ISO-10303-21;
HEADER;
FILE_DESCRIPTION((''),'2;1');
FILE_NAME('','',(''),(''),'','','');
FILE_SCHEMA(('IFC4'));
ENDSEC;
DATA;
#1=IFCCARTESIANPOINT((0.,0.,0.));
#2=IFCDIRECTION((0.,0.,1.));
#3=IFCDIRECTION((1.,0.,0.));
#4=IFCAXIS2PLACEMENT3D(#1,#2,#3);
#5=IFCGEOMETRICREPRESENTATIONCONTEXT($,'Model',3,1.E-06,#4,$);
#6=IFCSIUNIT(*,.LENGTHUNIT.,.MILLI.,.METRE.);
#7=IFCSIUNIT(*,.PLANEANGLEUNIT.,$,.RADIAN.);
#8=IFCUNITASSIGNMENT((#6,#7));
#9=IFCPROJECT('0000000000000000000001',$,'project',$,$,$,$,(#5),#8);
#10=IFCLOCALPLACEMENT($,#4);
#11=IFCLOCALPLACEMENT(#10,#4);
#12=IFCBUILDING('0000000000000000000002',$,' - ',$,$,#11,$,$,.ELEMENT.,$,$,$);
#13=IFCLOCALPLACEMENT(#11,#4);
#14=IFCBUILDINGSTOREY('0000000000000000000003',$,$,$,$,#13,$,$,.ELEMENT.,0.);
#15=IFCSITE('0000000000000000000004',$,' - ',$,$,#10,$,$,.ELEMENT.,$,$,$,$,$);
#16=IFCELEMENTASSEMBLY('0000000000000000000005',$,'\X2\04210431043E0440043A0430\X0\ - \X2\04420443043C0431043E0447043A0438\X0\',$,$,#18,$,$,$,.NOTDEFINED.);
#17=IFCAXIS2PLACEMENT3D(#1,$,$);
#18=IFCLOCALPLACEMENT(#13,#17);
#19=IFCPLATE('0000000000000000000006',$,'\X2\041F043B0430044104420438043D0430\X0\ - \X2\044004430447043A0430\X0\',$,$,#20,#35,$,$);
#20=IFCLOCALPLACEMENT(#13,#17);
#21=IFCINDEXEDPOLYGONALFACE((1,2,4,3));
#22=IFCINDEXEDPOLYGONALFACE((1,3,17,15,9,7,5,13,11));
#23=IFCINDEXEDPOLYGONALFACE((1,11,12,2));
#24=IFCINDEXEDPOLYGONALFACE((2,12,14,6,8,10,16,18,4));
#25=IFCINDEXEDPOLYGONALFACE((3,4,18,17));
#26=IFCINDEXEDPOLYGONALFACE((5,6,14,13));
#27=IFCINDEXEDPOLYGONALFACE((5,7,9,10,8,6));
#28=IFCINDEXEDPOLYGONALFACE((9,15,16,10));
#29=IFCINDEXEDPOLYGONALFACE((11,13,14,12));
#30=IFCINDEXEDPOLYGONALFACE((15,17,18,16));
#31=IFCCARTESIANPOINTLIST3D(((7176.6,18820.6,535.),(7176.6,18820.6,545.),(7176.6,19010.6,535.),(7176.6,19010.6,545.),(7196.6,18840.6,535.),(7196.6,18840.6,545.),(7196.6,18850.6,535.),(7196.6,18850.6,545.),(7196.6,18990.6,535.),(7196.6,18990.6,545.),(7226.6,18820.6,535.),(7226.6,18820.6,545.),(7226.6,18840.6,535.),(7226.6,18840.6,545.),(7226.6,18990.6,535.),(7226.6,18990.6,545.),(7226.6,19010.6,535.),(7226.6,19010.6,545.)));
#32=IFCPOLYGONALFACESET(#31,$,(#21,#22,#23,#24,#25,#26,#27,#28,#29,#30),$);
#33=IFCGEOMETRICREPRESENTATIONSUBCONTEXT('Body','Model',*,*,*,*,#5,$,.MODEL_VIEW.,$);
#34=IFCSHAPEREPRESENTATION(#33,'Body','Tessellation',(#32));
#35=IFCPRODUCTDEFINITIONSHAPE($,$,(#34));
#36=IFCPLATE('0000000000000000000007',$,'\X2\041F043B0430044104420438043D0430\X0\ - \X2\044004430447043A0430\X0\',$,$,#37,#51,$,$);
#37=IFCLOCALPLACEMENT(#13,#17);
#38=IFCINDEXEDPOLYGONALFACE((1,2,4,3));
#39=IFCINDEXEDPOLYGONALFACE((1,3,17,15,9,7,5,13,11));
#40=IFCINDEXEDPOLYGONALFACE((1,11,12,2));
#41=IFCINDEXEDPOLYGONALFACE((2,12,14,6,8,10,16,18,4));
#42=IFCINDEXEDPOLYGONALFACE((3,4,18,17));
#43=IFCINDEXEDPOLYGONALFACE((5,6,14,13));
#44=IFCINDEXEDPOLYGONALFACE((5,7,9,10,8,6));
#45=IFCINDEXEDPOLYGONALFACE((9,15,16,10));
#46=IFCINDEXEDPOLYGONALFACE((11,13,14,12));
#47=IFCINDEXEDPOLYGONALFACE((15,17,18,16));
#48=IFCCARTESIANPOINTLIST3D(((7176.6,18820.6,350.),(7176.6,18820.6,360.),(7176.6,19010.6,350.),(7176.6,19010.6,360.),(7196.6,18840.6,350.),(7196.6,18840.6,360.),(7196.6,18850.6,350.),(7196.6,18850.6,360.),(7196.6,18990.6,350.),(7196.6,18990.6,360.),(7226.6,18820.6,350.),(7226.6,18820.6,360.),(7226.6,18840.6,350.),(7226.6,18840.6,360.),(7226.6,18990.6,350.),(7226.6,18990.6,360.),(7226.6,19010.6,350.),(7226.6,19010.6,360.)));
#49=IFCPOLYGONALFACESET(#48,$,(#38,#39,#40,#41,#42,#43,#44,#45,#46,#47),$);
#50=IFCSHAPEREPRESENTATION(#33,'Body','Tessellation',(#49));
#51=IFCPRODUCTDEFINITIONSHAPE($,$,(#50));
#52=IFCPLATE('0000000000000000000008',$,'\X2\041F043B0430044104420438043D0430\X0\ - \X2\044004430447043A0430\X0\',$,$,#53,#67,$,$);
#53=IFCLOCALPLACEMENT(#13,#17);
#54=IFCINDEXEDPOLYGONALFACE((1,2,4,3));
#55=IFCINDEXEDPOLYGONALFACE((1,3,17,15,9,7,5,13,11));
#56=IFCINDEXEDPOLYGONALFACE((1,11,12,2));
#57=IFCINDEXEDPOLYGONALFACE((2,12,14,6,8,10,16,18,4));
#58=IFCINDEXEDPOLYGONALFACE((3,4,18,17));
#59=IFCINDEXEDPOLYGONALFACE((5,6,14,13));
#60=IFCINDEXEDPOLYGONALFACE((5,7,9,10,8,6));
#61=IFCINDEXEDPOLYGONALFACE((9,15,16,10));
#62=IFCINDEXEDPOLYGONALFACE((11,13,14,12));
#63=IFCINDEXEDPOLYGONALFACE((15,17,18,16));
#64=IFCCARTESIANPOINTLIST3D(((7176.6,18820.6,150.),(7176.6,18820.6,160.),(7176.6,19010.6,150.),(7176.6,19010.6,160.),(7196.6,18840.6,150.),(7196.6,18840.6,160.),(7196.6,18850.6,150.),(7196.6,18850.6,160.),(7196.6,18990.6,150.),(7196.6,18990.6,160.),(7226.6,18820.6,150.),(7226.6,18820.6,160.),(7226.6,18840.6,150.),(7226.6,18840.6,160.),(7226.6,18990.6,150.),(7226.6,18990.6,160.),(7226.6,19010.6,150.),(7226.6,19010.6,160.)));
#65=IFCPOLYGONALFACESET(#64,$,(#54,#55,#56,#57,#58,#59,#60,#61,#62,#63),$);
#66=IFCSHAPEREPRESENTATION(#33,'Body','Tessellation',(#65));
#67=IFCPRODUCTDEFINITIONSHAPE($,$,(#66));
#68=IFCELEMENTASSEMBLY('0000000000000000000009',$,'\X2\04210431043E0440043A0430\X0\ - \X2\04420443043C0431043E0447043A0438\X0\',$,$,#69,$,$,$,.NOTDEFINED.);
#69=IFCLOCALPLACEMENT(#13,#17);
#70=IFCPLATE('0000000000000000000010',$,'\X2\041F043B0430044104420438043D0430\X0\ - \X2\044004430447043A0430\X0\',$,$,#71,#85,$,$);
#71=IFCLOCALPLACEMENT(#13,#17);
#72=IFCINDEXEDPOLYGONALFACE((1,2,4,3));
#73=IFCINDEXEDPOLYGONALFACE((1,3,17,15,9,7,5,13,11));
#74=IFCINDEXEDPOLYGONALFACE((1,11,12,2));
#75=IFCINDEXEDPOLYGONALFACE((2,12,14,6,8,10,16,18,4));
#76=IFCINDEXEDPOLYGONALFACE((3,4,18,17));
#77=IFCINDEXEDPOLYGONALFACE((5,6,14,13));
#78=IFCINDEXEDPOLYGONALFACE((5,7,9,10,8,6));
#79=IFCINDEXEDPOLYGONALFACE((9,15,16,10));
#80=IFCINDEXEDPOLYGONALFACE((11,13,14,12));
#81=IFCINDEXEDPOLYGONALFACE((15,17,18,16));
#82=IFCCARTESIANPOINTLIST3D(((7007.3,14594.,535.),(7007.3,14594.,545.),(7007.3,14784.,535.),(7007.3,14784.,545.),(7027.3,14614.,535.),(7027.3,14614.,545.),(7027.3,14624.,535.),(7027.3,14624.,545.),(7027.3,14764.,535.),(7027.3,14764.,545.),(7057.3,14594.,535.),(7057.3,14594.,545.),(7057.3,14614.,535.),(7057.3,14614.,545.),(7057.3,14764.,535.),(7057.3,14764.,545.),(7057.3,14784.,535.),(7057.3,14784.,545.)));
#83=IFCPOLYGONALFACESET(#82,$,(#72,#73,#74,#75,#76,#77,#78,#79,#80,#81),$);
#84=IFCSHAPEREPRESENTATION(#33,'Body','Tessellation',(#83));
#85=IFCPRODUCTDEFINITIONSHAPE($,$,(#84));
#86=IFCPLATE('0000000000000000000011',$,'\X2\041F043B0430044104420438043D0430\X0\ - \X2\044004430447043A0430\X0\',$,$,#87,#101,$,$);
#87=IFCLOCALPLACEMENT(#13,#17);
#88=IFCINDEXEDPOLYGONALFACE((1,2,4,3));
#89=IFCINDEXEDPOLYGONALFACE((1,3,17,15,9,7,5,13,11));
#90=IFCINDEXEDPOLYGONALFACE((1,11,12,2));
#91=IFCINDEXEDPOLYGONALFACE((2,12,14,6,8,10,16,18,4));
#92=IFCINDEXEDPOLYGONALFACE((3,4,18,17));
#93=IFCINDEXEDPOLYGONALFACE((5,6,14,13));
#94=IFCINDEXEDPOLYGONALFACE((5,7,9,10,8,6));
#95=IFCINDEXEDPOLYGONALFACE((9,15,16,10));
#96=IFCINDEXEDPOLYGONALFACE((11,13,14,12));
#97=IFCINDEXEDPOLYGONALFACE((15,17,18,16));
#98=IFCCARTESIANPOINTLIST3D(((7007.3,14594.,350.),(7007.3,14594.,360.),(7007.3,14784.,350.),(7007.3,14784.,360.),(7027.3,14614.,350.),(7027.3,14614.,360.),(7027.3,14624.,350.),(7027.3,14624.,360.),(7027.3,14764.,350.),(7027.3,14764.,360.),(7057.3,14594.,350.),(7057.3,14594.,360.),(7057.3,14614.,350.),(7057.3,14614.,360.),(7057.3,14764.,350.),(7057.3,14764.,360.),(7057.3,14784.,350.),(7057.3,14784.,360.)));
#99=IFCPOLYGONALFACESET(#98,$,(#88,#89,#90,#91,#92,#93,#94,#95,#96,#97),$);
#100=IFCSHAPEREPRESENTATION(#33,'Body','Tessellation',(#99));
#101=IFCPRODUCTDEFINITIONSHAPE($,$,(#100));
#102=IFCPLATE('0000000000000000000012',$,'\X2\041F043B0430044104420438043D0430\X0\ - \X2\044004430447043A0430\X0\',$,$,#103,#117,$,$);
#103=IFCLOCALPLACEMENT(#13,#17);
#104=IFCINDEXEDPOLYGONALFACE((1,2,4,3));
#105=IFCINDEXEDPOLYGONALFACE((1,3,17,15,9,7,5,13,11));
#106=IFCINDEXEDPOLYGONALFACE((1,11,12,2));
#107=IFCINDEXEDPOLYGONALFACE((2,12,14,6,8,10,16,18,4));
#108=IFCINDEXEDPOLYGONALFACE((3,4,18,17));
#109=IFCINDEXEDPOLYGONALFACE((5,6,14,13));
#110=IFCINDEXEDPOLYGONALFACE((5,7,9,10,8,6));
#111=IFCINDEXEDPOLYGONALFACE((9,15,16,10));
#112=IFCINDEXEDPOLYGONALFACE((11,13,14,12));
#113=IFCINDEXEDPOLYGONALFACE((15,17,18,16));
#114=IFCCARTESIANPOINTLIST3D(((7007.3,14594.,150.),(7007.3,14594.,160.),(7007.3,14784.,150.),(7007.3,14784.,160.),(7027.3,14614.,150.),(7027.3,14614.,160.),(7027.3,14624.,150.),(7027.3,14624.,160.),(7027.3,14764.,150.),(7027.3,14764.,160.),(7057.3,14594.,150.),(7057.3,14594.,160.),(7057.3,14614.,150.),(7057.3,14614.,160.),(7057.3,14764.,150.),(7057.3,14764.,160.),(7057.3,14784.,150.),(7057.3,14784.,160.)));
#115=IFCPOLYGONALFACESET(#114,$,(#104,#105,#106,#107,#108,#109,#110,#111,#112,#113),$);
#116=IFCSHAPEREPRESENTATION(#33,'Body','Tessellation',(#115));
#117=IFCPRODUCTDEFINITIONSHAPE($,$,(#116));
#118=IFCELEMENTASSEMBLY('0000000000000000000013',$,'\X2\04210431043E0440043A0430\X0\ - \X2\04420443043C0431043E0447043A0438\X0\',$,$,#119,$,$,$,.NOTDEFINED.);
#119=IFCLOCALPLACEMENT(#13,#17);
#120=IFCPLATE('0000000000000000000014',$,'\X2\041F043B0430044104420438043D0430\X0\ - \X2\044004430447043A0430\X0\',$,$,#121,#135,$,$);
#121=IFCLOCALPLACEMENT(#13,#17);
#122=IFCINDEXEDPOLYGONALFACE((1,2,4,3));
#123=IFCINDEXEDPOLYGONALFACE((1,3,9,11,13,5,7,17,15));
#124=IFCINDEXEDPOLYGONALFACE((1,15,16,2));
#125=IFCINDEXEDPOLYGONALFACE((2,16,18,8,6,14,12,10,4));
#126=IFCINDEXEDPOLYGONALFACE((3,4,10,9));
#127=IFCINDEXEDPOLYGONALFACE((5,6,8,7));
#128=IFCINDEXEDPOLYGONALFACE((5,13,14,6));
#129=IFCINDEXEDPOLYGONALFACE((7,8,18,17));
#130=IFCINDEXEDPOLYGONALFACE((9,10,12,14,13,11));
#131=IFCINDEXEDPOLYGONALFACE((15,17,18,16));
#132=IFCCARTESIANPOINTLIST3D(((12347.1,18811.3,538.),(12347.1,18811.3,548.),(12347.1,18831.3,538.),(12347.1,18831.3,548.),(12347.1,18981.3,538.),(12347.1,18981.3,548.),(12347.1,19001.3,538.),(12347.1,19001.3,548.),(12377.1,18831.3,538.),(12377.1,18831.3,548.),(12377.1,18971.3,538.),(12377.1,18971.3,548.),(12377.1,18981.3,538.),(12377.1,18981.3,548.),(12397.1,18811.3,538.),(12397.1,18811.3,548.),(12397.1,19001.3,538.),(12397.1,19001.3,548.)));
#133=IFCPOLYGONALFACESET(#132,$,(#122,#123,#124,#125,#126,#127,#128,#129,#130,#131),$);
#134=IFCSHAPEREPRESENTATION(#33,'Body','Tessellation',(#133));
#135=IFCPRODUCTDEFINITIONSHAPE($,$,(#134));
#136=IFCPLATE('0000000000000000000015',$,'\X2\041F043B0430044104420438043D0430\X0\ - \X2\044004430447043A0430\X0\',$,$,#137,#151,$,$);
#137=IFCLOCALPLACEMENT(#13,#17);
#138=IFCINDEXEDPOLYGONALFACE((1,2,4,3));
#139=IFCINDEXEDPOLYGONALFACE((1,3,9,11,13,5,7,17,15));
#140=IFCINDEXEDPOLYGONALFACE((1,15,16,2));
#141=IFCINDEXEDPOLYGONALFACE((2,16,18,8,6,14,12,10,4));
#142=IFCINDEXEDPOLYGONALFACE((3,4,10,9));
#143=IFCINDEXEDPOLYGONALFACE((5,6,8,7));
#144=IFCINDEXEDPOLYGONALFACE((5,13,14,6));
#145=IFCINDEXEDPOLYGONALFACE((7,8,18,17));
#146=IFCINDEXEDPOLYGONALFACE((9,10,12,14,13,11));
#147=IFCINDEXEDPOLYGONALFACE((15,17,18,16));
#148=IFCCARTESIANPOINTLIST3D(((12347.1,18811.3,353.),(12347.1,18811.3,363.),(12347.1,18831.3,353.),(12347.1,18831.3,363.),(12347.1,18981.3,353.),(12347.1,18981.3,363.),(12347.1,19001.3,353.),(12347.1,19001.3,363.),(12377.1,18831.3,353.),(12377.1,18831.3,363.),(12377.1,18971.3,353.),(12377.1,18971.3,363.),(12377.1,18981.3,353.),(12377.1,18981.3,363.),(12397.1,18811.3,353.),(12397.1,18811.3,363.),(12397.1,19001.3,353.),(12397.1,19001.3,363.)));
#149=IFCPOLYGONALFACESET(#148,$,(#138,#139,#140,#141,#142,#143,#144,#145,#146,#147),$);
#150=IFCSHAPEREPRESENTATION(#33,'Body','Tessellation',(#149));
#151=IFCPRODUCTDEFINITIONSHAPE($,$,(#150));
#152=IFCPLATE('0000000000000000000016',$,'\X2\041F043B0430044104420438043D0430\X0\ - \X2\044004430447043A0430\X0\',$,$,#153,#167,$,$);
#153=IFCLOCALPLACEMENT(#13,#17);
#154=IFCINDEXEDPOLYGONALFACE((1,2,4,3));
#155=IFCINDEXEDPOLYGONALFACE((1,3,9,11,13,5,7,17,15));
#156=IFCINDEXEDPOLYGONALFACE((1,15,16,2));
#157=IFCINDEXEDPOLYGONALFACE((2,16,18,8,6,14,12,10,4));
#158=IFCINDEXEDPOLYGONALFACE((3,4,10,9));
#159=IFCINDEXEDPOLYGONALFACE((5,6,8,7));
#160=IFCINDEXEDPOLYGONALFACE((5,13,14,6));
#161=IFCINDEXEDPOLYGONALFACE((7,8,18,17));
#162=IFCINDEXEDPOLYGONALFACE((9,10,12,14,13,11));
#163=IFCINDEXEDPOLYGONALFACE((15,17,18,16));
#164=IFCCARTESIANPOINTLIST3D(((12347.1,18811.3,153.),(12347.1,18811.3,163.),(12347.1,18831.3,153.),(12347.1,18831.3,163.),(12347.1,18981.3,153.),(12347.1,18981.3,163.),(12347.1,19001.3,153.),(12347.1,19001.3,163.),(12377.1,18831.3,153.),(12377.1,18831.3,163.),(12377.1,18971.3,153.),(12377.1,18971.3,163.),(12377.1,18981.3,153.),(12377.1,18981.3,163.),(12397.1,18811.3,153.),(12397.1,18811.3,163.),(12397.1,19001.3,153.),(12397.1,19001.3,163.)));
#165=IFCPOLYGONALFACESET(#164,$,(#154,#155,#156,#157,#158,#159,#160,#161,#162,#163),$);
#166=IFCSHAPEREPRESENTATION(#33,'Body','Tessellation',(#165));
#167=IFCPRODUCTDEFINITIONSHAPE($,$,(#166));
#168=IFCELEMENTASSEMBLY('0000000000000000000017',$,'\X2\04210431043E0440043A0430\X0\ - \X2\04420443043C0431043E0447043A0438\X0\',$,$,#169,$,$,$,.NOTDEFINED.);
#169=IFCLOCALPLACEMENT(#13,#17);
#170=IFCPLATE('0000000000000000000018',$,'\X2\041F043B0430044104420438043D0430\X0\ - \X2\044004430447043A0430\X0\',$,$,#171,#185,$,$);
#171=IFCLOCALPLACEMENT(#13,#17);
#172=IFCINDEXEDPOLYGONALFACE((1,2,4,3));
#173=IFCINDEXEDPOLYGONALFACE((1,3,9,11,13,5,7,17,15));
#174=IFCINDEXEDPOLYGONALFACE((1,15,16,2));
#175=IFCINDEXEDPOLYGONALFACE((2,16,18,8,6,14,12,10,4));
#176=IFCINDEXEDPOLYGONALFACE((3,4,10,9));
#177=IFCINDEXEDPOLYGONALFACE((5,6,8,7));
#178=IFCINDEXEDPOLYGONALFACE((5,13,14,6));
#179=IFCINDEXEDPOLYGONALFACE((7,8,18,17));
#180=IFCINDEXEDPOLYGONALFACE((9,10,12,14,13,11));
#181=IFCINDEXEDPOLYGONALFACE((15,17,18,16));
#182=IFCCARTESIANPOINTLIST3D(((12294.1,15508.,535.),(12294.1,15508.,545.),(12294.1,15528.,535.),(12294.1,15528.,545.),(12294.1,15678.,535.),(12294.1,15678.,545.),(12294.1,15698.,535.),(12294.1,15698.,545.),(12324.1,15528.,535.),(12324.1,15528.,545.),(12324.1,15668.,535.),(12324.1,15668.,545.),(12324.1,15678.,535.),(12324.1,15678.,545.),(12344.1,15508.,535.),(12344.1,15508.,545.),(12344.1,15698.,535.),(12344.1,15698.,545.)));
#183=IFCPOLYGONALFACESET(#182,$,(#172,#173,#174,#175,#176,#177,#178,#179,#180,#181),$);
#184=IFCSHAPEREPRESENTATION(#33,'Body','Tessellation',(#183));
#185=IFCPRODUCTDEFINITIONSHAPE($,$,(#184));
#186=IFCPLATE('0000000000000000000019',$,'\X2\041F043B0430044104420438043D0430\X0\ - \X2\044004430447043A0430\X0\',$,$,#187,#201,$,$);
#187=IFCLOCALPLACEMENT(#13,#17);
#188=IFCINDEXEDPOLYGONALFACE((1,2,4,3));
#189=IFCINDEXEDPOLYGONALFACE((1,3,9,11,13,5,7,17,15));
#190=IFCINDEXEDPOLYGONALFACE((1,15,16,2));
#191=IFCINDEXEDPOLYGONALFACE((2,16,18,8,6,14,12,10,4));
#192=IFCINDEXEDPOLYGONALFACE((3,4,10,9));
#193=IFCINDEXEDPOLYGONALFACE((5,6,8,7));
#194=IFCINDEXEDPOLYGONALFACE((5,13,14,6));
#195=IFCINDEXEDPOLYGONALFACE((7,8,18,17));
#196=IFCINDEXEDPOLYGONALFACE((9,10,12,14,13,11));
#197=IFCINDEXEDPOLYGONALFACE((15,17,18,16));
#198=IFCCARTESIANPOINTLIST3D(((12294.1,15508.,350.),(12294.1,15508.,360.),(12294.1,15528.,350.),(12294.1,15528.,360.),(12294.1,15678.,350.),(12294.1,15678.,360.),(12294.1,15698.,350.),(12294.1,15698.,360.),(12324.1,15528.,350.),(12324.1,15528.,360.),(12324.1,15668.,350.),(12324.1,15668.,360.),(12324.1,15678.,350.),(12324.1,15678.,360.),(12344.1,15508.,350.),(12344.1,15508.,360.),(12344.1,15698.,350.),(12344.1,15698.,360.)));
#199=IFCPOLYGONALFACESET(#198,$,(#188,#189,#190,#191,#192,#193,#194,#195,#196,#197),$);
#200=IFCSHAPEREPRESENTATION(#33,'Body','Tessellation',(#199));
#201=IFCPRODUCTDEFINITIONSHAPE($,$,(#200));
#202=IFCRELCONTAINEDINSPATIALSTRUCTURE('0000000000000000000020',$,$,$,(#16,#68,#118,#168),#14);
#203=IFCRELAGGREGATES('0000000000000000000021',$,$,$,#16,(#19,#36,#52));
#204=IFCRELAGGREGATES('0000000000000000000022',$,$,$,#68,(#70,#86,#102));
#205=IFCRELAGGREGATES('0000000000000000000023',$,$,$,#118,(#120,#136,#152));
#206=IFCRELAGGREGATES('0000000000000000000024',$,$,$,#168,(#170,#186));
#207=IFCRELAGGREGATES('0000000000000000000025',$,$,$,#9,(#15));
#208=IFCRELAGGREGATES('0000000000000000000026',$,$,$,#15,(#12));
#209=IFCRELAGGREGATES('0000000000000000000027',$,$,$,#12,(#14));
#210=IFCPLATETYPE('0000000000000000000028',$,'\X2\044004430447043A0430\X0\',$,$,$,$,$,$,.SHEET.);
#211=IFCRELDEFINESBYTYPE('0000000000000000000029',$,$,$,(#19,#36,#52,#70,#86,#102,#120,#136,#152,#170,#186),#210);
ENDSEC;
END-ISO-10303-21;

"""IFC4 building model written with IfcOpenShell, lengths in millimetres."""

from ifc_helpers import new_model, si_unit, frame, origin_with_axes, place, context, subcontext, project, spatial, line, indexed_curve, outline, extrude, source, transform, mapped, type_object, element, aggregate, save


model = new_model("IFC4")

# Units and contexts
model_context = context("Model", 3, precision=1e-06, world=origin_with_axes())
body_context = subcontext(model_context, "Body", "Model", "MODEL_VIEW")
ifc_project = project(units=[si_unit("LENGTHUNIT", "METRE", prefix="MILLI"), si_unit("PLANEANGLEUNIT", "RADIAN")], contexts=[model_context])

# Site, building, storey
site_placement = place(None, origin_with_axes())
site = spatial("IfcSite", under=ifc_project, at=site_placement, Name=" - ", CompositionType="ELEMENT")
building_placement = place(site_placement, origin_with_axes())
building = spatial("IfcBuilding", under=site, at=building_placement, Name=" - ", CompositionType="ELEMENT")
storey_placement = place(building_placement, origin_with_axes())
storey = spatial("IfcBuildingStorey", under=building, at=storey_placement, CompositionType="ELEMENT", Elevation=0.0)

# Element assemblies, plates
plate_type = type_object("IfcPlateType", Name="ручка", PredefinedType="SHEET")
shared_shape = source(origin_with_axes(), body_context, "Body", "SweptSolid", [
    extrude(outline(indexed_curve([(-95.0, -25.0), (-75.0, -25.0), (-75.0, 5.0), (-65.0, 5.0), (75.0, 5.0), (75.0, -25.0), (95.0, -25.0), (95.0, 25.0), (-95.0, 25.0)], segments=[line(1, 2), line(2, 3), line(3, 4), line(4, 5), line(5, 6), line(6, 7), line(7, 8), line(8, 9), line(9, 1)])), origin_with_axes(), (0.0, 0.0, 1.0), 10.0),
])
assembly_1_placement = place(storey_placement, frame((7226.6, 19115.6, 0.0), z_axis=(0.0, 0.0, 1.0), x_axis=(0.0, -1.0, 0.0)))
assembly_1 = element("IfcElementAssembly", 1, at=assembly_1_placement, inside=storey, Name="Сборка - тумбочки", PredefinedType="NOTDEFINED")
plate_1_placement = place(assembly_1_placement, frame((200.0, -25.0, 535.0), z_axis=(0.0, 0.0, 1.0), x_axis=(-1.0, 0.0, 0.0)))
plate_1 = element("IfcPlate", 2, at=plate_1_placement, type_object=plate_type, Name="Пластина - ручка", context=body_context, shape_type="MappedRepresentation", body=[
    mapped(shared_shape, transform((0.0, 0.0, 0.0), x_axis=(1.0, 0.0, 0.0), y_axis=(0.0, 1.0, 0.0), z_axis=(0.0, 0.0, 1.0), scale=1.0)),
])
plate_2_placement = place(assembly_1_placement, frame((200.0, -25.0, 350.0), z_axis=(0.0, 0.0, 1.0), x_axis=(-1.0, 0.0, 0.0)))
plate_2 = element("IfcPlate", 3, at=plate_2_placement, type_object=plate_type, Name="Пластина - ручка", context=body_context, shape_type="MappedRepresentation", body=[
    mapped(shared_shape, transform((0.0, 0.0, 0.0), x_axis=(1.0, 0.0, 0.0), y_axis=(0.0, 1.0, 0.0), z_axis=(0.0, 0.0, 1.0), scale=1.0)),
])
plate_3_placement = place(assembly_1_placement, frame((200.0, -25.0, 150.0), z_axis=(0.0, 0.0, 1.0), x_axis=(-1.0, 0.0, 0.0)))
plate_3 = element("IfcPlate", 4, at=plate_3_placement, type_object=plate_type, Name="Пластина - ручка", context=body_context, shape_type="MappedRepresentation", body=[
    mapped(shared_shape, transform((0.0, 0.0, 0.0), x_axis=(1.0, 0.0, 0.0), y_axis=(0.0, 1.0, 0.0), z_axis=(0.0, 0.0, 1.0), scale=1.0)),
])
aggregate(assembly_1, [plate_1, plate_2, plate_3])
assembly_2_placement = place(storey_placement, frame((7057.3, 14889.0, 0.0), z_axis=(0.0, 0.0, 1.0), x_axis=(0.0, -1.0, 0.0)))
assembly_2 = element("IfcElementAssembly", 5, at=assembly_2_placement, inside=storey, Name="Сборка - тумбочки", PredefinedType="NOTDEFINED")
plate_4_placement = place(assembly_2_placement, frame((200.0, -25.0, 535.0), z_axis=(0.0, 0.0, 1.0), x_axis=(-1.0, 0.0, 0.0)))
plate_4 = element("IfcPlate", 6, at=plate_4_placement, type_object=plate_type, Name="Пластина - ручка", context=body_context, shape_type="MappedRepresentation", body=[
    mapped(shared_shape, transform((0.0, 0.0, 0.0), x_axis=(1.0, 0.0, 0.0), y_axis=(0.0, 1.0, 0.0), z_axis=(0.0, 0.0, 1.0), scale=1.0)),
])
plate_5_placement = place(assembly_2_placement, frame((200.0, -25.0, 350.0), z_axis=(0.0, 0.0, 1.0), x_axis=(-1.0, 0.0, 0.0)))
plate_5 = element("IfcPlate", 7, at=plate_5_placement, type_object=plate_type, Name="Пластина - ручка", context=body_context, shape_type="MappedRepresentation", body=[
    mapped(shared_shape, transform((0.0, 0.0, 0.0), x_axis=(1.0, 0.0, 0.0), y_axis=(0.0, 1.0, 0.0), z_axis=(0.0, 0.0, 1.0), scale=1.0)),
])
plate_6_placement = place(assembly_2_placement, frame((200.0, -25.0, 150.0), z_axis=(0.0, 0.0, 1.0), x_axis=(-1.0, 0.0, 0.0)))
plate_6 = element("IfcPlate", 8, at=plate_6_placement, type_object=plate_type, Name="Пластина - ручка", context=body_context, shape_type="MappedRepresentation", body=[
    mapped(shared_shape, transform((0.0, 0.0, 0.0), x_axis=(1.0, 0.0, 0.0), y_axis=(0.0, 1.0, 0.0), z_axis=(0.0, 0.0, 1.0), scale=1.0)),
])
aggregate(assembly_2, [plate_4, plate_5, plate_6])
assembly_3_placement = place(storey_placement, frame((12347.1, 18706.3, 3.0), z_axis=(0.0, 0.0, 1.0), x_axis=(0.0, 1.0, 0.0)))
assembly_3 = element("IfcElementAssembly", 9, at=assembly_3_placement, inside=storey, Name="Сборка - тумбочки", PredefinedType="NOTDEFINED")
plate_7_placement = place(assembly_3_placement, frame((200.0, -25.0, 535.0), z_axis=(0.0, 0.0, 1.0), x_axis=(-1.0, 0.0, 0.0)))
plate_7 = element("IfcPlate", 10, at=plate_7_placement, type_object=plate_type, Name="Пластина - ручка", context=body_context, shape_type="MappedRepresentation", body=[
    mapped(shared_shape, transform((0.0, 0.0, 0.0), x_axis=(1.0, 0.0, 0.0), y_axis=(0.0, 1.0, 0.0), z_axis=(0.0, 0.0, 1.0), scale=1.0)),
])
plate_8_placement = place(assembly_3_placement, frame((200.0, -25.0, 350.0), z_axis=(0.0, 0.0, 1.0), x_axis=(-1.0, 0.0, 0.0)))
plate_8 = element("IfcPlate", 11, at=plate_8_placement, type_object=plate_type, Name="Пластина - ручка", context=body_context, shape_type="MappedRepresentation", body=[
    mapped(shared_shape, transform((0.0, 0.0, 0.0), x_axis=(1.0, 0.0, 0.0), y_axis=(0.0, 1.0, 0.0), z_axis=(0.0, 0.0, 1.0), scale=1.0)),
])
plate_9_placement = place(assembly_3_placement, frame((200.0, -25.0, 150.0), z_axis=(0.0, 0.0, 1.0), x_axis=(-1.0, 0.0, 0.0)))
plate_9 = element("IfcPlate", 12, at=plate_9_placement, type_object=plate_type, Name="Пластина - ручка", context=body_context, shape_type="MappedRepresentation", body=[
    mapped(shared_shape, transform((0.0, 0.0, 0.0), x_axis=(1.0, 0.0, 0.0), y_axis=(0.0, 1.0, 0.0), z_axis=(0.0, 0.0, 1.0), scale=1.0)),
])
aggregate(assembly_3, [plate_7, plate_8, plate_9])
assembly_4_placement = place(storey_placement, frame((12294.1, 15403.0, 0.0), z_axis=(0.0, 0.0, 1.0), x_axis=(0.0, 1.0, 0.0)))
assembly_4 = element("IfcElementAssembly", 13, at=assembly_4_placement, inside=storey, Name="Сборка - тумбочки", PredefinedType="NOTDEFINED")
plate_10_placement = place(assembly_4_placement, frame((200.0, -25.0, 535.0), z_axis=(0.0, 0.0, 1.0), x_axis=(-1.0, 0.0, 0.0)))
plate_10 = element("IfcPlate", 14, at=plate_10_placement, type_object=plate_type, Name="Пластина - ручка", context=body_context, shape_type="MappedRepresentation", body=[
    mapped(shared_shape, transform((0.0, 0.0, 0.0), x_axis=(1.0, 0.0, 0.0), y_axis=(0.0, 1.0, 0.0), z_axis=(0.0, 0.0, 1.0), scale=1.0)),
])
plate_11_placement = place(assembly_4_placement, frame((200.0, -25.0, 350.0), z_axis=(0.0, 0.0, 1.0), x_axis=(-1.0, 0.0, 0.0)))
plate_11 = element("IfcPlate", 15, at=plate_11_placement, type_object=plate_type, Name="Пластина - ручка", context=body_context, shape_type="MappedRepresentation", body=[
    mapped(shared_shape, transform((0.0, 0.0, 0.0), x_axis=(1.0, 0.0, 0.0), y_axis=(0.0, 1.0, 0.0), z_axis=(0.0, 0.0, 1.0), scale=1.0)),
])
aggregate(assembly_4, [plate_10, plate_11])

save(model, "model.ifc")
